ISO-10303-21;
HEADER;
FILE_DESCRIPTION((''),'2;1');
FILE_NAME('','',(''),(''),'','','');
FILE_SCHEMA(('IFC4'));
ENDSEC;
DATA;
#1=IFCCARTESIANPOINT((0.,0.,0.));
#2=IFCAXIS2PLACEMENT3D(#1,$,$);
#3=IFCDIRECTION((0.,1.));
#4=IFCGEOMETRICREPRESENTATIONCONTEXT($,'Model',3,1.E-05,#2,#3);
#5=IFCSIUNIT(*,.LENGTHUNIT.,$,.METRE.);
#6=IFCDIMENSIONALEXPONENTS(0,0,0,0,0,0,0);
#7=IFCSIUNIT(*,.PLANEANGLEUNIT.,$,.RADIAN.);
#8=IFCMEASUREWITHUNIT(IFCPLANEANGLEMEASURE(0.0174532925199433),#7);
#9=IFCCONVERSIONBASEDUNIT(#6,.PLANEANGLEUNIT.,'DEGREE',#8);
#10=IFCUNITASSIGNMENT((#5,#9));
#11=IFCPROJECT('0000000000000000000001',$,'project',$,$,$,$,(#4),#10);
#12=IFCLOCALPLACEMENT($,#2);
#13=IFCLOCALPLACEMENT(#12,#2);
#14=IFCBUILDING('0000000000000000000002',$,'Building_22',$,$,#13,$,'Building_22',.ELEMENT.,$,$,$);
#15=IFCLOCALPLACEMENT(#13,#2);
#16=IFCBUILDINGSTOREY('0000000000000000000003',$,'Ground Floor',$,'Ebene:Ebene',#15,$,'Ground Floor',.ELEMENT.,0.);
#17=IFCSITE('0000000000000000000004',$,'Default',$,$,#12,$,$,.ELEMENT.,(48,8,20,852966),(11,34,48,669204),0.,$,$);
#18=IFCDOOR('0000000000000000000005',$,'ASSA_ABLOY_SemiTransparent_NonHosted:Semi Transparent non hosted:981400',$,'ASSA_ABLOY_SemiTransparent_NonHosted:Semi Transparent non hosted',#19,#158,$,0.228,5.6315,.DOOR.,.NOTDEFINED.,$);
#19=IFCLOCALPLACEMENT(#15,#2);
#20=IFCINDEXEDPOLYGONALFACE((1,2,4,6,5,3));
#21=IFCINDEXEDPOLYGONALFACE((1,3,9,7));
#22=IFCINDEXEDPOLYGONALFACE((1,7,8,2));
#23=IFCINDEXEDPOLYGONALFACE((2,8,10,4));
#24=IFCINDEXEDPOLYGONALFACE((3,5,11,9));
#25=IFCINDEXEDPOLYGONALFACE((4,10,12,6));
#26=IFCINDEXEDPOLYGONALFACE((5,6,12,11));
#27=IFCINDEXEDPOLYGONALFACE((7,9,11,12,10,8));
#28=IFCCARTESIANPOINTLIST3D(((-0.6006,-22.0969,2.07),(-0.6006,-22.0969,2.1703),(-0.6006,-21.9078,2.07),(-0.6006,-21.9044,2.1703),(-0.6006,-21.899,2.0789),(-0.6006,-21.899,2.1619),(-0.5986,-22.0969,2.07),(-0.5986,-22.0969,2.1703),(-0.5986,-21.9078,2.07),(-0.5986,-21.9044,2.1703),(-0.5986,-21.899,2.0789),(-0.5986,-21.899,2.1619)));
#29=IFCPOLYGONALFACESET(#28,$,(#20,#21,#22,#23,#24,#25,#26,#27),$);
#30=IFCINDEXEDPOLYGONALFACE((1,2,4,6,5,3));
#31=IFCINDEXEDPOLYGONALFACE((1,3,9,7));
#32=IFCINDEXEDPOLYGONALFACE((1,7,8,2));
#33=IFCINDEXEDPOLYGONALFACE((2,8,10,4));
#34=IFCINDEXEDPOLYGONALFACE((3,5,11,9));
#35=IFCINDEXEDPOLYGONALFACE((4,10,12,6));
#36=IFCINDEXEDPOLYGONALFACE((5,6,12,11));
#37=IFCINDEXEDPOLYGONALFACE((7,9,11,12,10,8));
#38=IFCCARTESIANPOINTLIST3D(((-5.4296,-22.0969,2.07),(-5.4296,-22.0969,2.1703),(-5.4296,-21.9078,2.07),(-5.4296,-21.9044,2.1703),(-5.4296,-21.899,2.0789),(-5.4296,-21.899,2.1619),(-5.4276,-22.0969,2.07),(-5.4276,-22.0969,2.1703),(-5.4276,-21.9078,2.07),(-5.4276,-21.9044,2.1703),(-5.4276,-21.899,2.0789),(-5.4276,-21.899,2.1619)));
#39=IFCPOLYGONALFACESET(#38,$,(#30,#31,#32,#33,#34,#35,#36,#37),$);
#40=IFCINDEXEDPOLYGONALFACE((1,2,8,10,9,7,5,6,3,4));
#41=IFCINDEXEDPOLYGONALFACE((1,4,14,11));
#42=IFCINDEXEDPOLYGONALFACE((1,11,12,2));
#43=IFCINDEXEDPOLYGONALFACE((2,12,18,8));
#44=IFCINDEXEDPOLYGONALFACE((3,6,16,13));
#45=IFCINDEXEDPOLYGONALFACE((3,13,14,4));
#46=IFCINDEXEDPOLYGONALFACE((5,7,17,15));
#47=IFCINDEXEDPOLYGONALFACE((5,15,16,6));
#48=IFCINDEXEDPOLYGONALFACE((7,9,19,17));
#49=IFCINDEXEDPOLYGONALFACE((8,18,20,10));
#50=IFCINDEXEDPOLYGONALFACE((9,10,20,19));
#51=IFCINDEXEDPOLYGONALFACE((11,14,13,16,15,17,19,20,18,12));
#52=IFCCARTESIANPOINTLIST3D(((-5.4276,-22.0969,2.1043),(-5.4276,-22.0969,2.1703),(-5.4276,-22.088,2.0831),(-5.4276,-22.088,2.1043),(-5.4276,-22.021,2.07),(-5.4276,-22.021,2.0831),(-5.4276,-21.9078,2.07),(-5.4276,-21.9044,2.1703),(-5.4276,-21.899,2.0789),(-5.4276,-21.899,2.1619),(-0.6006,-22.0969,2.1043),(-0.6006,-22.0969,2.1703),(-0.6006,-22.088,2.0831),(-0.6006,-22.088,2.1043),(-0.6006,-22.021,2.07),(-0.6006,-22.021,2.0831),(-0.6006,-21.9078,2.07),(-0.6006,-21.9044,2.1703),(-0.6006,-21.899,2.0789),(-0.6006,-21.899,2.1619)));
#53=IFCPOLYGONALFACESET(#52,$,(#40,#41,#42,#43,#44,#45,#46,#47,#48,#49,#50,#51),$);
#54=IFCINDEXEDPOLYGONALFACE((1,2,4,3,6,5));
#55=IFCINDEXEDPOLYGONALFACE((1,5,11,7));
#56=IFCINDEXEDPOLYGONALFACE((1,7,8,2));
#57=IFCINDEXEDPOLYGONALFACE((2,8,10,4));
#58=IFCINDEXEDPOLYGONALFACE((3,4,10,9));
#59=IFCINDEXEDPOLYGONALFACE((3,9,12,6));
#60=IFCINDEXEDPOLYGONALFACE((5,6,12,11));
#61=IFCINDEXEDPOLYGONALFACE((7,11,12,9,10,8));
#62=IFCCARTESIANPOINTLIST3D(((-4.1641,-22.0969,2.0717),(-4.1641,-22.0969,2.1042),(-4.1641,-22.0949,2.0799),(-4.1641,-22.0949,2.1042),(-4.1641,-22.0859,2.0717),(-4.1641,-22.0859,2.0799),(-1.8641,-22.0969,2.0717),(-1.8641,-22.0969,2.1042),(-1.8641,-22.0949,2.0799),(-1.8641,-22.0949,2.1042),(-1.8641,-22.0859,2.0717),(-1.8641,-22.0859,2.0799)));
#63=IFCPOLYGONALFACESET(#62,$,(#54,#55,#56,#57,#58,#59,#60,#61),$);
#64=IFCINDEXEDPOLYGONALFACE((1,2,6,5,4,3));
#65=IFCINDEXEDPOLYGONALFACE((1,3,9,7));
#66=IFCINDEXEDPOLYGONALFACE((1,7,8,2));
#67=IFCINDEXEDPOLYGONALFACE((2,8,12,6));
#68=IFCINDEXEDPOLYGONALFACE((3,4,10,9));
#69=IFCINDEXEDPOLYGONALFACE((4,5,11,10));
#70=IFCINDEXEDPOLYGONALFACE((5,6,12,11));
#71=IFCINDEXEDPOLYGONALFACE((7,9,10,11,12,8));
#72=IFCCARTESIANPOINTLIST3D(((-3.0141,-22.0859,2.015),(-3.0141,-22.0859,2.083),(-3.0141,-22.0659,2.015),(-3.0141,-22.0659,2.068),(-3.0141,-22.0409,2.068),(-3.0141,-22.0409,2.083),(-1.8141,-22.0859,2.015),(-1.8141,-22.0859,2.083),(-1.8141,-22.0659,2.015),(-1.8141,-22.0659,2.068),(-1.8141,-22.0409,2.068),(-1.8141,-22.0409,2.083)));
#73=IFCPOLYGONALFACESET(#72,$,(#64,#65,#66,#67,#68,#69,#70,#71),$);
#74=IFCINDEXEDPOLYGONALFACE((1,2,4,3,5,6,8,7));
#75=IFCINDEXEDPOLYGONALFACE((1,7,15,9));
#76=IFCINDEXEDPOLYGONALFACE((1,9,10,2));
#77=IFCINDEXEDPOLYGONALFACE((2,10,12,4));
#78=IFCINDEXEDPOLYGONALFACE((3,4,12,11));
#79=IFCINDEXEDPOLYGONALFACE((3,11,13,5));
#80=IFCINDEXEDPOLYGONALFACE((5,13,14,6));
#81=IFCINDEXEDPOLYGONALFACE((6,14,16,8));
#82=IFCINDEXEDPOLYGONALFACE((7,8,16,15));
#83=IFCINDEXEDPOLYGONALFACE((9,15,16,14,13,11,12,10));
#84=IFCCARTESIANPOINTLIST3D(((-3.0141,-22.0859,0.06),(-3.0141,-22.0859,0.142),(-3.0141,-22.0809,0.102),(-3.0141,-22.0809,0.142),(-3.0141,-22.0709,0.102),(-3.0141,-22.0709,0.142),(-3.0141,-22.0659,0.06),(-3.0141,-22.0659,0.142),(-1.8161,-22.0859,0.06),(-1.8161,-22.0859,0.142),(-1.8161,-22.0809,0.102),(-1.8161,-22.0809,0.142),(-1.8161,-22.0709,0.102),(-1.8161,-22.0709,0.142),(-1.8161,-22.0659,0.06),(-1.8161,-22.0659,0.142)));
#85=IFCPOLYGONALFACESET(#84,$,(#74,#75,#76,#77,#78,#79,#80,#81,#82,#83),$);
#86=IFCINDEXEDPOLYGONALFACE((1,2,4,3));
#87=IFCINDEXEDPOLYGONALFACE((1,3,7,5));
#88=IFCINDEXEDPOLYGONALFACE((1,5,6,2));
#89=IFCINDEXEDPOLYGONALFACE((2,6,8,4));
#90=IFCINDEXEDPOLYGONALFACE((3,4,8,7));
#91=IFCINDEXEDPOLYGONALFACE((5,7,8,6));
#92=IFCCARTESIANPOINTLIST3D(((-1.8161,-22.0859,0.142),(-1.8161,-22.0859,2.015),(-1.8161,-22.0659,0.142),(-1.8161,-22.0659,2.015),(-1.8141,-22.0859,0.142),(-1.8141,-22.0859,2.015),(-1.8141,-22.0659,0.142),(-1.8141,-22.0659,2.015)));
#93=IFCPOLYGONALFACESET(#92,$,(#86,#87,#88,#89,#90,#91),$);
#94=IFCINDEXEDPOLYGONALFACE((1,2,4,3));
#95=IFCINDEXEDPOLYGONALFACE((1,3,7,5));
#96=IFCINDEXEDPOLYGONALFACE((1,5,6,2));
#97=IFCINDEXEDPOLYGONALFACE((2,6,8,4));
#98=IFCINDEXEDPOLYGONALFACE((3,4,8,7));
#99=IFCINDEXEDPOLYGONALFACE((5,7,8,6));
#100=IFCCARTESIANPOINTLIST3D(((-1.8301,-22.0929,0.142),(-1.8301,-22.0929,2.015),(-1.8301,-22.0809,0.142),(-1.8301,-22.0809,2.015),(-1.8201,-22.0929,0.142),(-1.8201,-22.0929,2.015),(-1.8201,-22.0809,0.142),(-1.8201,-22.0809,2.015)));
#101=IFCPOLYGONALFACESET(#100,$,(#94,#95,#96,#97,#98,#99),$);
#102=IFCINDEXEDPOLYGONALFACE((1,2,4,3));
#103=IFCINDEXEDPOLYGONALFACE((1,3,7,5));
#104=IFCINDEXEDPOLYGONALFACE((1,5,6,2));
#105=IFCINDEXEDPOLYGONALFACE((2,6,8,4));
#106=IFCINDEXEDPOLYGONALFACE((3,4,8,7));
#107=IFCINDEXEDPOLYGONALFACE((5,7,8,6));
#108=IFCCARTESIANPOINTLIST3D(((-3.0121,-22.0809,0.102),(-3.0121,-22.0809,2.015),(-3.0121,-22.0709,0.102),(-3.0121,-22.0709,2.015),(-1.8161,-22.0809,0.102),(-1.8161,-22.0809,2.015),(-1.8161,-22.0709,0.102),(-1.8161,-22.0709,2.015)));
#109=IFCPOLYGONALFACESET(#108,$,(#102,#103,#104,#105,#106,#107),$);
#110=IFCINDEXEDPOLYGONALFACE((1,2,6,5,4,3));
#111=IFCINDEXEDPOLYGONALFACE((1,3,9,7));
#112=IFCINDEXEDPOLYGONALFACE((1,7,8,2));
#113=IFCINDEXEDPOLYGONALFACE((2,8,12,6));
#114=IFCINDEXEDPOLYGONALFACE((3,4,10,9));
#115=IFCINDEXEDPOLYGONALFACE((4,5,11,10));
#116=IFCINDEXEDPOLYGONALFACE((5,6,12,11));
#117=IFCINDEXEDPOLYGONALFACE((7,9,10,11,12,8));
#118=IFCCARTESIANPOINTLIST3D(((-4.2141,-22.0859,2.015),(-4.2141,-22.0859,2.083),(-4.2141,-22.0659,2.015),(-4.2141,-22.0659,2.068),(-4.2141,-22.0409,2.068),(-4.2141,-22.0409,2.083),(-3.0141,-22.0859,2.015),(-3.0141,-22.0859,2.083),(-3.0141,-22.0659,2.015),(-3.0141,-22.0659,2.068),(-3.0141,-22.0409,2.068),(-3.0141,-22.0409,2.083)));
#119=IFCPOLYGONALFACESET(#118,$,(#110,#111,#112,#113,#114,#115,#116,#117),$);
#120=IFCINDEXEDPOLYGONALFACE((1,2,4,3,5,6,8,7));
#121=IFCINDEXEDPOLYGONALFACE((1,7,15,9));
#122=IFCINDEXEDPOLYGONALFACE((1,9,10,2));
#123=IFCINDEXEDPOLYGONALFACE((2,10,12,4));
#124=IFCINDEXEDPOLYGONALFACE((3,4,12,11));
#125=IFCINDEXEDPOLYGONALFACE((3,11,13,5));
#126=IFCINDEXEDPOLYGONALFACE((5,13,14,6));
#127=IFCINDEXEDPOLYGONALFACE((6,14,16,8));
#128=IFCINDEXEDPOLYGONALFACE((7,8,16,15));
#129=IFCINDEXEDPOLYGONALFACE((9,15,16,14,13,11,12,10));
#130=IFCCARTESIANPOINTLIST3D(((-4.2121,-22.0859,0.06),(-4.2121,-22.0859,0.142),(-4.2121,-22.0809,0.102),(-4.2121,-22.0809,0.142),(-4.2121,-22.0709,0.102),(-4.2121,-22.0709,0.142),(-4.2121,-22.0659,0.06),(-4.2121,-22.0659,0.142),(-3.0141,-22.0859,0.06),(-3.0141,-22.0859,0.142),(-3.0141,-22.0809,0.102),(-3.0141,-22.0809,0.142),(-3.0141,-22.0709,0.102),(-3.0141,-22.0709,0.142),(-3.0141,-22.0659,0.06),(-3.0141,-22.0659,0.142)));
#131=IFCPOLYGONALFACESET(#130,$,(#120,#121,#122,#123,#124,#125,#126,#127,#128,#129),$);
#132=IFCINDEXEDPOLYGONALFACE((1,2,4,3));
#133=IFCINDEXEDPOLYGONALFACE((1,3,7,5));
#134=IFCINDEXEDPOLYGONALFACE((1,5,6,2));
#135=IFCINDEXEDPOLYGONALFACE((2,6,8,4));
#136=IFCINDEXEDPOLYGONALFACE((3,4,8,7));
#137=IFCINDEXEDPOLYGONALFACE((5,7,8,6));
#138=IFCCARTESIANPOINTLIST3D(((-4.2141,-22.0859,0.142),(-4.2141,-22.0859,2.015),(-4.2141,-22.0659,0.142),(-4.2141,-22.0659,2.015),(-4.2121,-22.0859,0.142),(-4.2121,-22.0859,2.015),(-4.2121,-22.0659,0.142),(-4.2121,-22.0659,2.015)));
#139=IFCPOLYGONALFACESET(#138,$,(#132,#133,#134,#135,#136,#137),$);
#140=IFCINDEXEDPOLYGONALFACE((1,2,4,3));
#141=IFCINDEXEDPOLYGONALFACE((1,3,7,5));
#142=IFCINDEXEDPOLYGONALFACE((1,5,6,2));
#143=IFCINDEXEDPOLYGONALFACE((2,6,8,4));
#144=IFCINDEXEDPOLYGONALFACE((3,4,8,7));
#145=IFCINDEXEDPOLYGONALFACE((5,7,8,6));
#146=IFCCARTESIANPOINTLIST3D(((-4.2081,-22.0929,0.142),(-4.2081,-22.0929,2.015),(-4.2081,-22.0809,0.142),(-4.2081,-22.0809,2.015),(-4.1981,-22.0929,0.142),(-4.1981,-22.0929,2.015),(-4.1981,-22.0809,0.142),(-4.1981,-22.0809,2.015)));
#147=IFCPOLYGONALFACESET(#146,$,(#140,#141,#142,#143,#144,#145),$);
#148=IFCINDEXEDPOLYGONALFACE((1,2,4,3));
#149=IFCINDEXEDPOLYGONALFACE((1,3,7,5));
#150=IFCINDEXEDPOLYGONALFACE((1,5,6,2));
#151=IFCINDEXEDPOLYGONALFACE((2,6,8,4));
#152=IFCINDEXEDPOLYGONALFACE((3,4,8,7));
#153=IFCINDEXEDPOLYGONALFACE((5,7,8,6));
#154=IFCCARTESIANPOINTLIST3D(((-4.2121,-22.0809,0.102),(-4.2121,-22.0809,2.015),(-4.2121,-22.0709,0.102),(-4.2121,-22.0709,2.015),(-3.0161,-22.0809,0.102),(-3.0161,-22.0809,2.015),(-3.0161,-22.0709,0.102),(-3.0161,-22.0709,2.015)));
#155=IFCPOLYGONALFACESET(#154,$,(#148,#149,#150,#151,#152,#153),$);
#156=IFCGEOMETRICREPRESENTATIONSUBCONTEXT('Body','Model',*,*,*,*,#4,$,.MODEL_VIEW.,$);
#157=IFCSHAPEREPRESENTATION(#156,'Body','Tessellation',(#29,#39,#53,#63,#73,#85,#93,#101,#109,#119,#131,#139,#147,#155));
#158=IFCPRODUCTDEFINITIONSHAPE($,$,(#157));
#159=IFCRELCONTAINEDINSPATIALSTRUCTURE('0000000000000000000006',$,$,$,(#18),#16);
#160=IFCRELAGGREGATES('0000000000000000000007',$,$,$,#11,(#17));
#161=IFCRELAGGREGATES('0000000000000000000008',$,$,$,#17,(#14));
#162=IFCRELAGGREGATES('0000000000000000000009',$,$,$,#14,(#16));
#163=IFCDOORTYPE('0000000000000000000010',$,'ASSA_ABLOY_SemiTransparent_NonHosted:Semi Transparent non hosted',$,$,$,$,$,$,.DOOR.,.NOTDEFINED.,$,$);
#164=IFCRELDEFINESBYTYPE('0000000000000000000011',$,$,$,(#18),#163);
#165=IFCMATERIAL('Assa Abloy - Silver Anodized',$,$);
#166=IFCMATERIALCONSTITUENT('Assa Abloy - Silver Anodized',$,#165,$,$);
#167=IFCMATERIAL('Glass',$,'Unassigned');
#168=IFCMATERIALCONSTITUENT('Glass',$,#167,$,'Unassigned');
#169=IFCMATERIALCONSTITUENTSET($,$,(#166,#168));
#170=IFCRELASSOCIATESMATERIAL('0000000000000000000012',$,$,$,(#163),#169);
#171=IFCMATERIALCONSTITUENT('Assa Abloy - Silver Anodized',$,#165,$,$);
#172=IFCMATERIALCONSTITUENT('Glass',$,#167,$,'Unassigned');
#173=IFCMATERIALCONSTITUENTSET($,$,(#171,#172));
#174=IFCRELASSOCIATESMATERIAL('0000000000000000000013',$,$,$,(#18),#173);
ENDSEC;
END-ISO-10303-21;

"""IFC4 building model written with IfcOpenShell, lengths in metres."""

from ifc_helpers import new_model, entity, si_unit, converted_unit, direction, frame, origin, place, context, subcontext, project, spatial, indexed_curve, outline, extrude, source, transform, mapped, material, constituent, constituent_set, type_object, type_shapes, element, save


model = new_model("IFC4")

# Units and contexts
model_context = context("Model", 3, precision=1e-05, world=origin(), true_north=direction((0.0, 1.0)))
body_context = subcontext(model_context, "Body", "Model", "MODEL_VIEW")
ifc_project = project(units=[si_unit("LENGTHUNIT", "METRE"), converted_unit("PLANEANGLEUNIT", "DEGREE", entity("IfcPlaneAngleMeasure", 0.0174532925199433), si_unit("PLANEANGLEUNIT", "RADIAN"), dimensions=[0, 0, 0, 0, 0, 0, 0])], contexts=[model_context])

# Site, building, storey
site_placement = place(None, origin())
site = spatial("IfcSite", under=ifc_project, at=site_placement, Name="Default", CompositionType="ELEMENT", RefLatitude=(48, 8, 20, 852966), RefLongitude=(11, 34, 48, 669204), RefElevation=0.0)
building_placement = place(site_placement, origin())
building = spatial("IfcBuilding", under=site, at=building_placement, Name="Building_22", LongName="Building_22", CompositionType="ELEMENT")
storey_placement = place(building_placement, origin())
storey = spatial("IfcBuildingStorey", under=building, at=storey_placement, Name="Ground Floor", ObjectType="Ebene:Ebene", LongName="Ground Floor", CompositionType="ELEMENT", Elevation=0.0)

# Door
ifc_material_1 = material(Name="Assa Abloy - Silver Anodized")
ifc_constituent_1 = constituent(ifc_material_1, Name="Assa Abloy - Silver Anodized")
ifc_material_2 = material(Name="Glass", Category="Unassigned")
ifc_constituent_2 = constituent(ifc_material_2, Name="Glass", Category="Unassigned")
ifc_constituent_set_1 = constituent_set(constituents=[ifc_constituent_1, ifc_constituent_2])
ifc_constituent_3 = constituent(ifc_material_1, Name="Assa Abloy - Silver Anodized")
ifc_constituent_4 = constituent(ifc_material_2, Name="Glass", Category="Unassigned")
ifc_constituent_set_2 = constituent_set(constituents=[ifc_constituent_3, ifc_constituent_4])
door_type = type_object("IfcDoorType", Name="ASSA_ABLOY_SemiTransparent_NonHosted:Semi Transparent non hosted", OperationType="NOTDEFINED", PredefinedType="DOOR", material=ifc_constituent_set_2)
shared_shape_1 = source(origin(), body_context, "Body", "SweptSolid", [
    extrude(outline(indexed_curve([(-0.0629, -0.0501), (0.1295, -0.0501), (0.1295, 0.0502), (-0.0595, 0.0502), (-0.0683, 0.0413), (-0.0683, -0.0417), (-0.0629, -0.0501)], self_intersect=False)), frame((2.4135, 0.1295, 2.0602), z_axis=(1.0, 0.0, 0.0), x_axis=(0.0, -1.0, 0.0)), (0.0, 0.0, 1.0), 0.002),
    extrude(outline(indexed_curve([(-0.0629, -0.0501), (0.1295, -0.0501), (0.1295, 0.0502), (-0.0595, 0.0502), (-0.0683, 0.0413), (-0.0683, -0.0417), (-0.0629, -0.0501)], self_intersect=False)), frame((-2.4155, 0.1295, 2.0602), z_axis=(1.0, 0.0, 0.0), x_axis=(0.0, -1.0, 0.0)), (0.0, 0.0, 1.0), 0.002),
    extrude(outline(indexed_curve([(-0.0947, 0.0054), (-0.0947, -0.0607), (0.0978, -0.0607), (0.1032, -0.0523), (0.1032, 0.0307), (0.0943, 0.0396), (-0.0188, 0.0396), (-0.0188, 0.0265), (-0.0858, 0.0265), (-0.0858, 0.0054), (-0.0947, 0.0054)], self_intersect=False)), frame((-2.4135, 0.0947, 2.0496), z_axis=(-1.0, 0.0, 0.0), x_axis=(0.0, 1.0, 0.0)), (0.0, 0.0, -1.0), 4.827),
    extrude(outline(indexed_curve([(-0.0136, -0.0067), (-0.0054, -0.0067), (-0.0054, 0.0023), (0.0189, 0.0023), (0.0189, 0.0043), (-0.0136, 0.0043), (-0.0136, -0.0067)], self_intersect=False)), frame((-1.15, 0.0043, 2.0253), z_axis=(1.0, 0.0, 0.0), x_axis=(0.0, 0.0, 1.0)), (0.0, 0.0, 1.0), 2.3),
    extrude(outline(indexed_curve([(-0.0233, -0.0277), (0.0217, -0.0277), (0.0217, 0.0403), (0.0017, 0.0403), (0.0017, -0.0127), (-0.0233, -0.0127), (-0.0233, -0.0277)], self_intersect=False)), frame((0.0, 0.0327, 1.9953), z_axis=(1.0, 0.0, 0.0), x_axis=(0.0, -1.0, 0.0)), (0.0, 0.0, 1.0), 1.2),
    extrude(outline(indexed_curve([(-0.01, -0.0515), (0.01, -0.0515), (0.01, 0.0305), (0.005, 0.0305), (0.005, -0.0095), (-0.005, -0.0095), (-0.005, 0.0305), (-0.01, 0.0305), (-0.01, -0.0515)], self_intersect=False)), frame((0.0, 0.021, 0.0515), z_axis=(1.0, 0.0, 0.0), x_axis=(0.0, 1.0, 0.0)), (0.0, 0.0, 1.0), 1.198),
    extrude(outline(indexed_curve([(-0.001, -0.01), (0.001, -0.01), (0.001, 0.01), (-0.001, 0.01), (-0.001, -0.01)], self_intersect=False)), frame((1.199, 0.021, 0.082), z_axis=(0.0, 0.0, 1.0), x_axis=(-1.0, 0.0, 0.0)), (0.0, 0.0, 1.0), 1.873),
    extrude(outline(indexed_curve([(-0.005, -0.006), (0.005, -0.006), (0.005, 0.006), (-0.005, 0.006), (-0.005, -0.006)], self_intersect=False)), frame((1.189, 0.01, 0.082)), (0.0, 0.0, 1.0), 1.873),
    extrude(outline(indexed_curve([(-0.598, -0.005), (0.598, -0.005), (0.598, 0.005), (-0.598, 0.005), (-0.598, -0.005)], self_intersect=False)), frame((0.6, 0.021, 0.042), z_axis=(0.0, 0.0, 1.0), x_axis=(-1.0, 0.0, 0.0)), (0.0, 0.0, 1.0), 1.913),
    extrude(outline(indexed_curve([(-0.0233, -0.0277), (0.0217, -0.0277), (0.0217, 0.0403), (0.0017, 0.0403), (0.0017, -0.0127), (-0.0233, -0.0127), (-0.0233, -0.0277)], self_intersect=False)), frame((-1.2, 0.0327, 1.9953), z_axis=(1.0, 0.0, 0.0), x_axis=(0.0, -1.0, 0.0)), (0.0, 0.0, 1.0), 1.2),
    extrude(outline(indexed_curve([(-0.01, -0.0515), (0.01, -0.0515), (0.01, 0.0305), (0.005, 0.0305), (0.005, -0.0095), (-0.005, -0.0095), (-0.005, 0.0305), (-0.01, 0.0305), (-0.01, -0.0515)], self_intersect=False)), frame((-1.198, 0.021, 0.0515), z_axis=(1.0, 0.0, 0.0), x_axis=(0.0, 1.0, 0.0)), (0.0, 0.0, 1.0), 1.198),
    extrude(outline(indexed_curve([(-0.01, -0.001), (0.01, -0.001), (0.01, 0.001), (-0.01, 0.001), (-0.01, -0.001)], self_intersect=False)), frame((-1.199, 0.021, 0.082), z_axis=(0.0, 0.0, 1.0), x_axis=(0.0, -1.0, 0.0)), (0.0, 0.0, 1.0), 1.873),
    extrude(outline(indexed_curve([(-0.006, -0.005), (0.006, -0.005), (0.006, 0.005), (-0.006, 0.005), (-0.006, -0.005)], self_intersect=False)), frame((-1.189, 0.01, 0.082), z_axis=(0.0, 0.0, 1.0), x_axis=(0.0, 1.0, 0.0)), (0.0, 0.0, 1.0), 1.873),
    extrude(outline(indexed_curve([(-0.005, -0.598), (0.005, -0.598), (0.005, 0.598), (-0.005, 0.598), (-0.005, -0.598)], self_intersect=False)), frame((-0.6, 0.021, 0.042), z_axis=(0.0, 0.0, 1.0), x_axis=(0.0, -1.0, 0.0)), (0.0, 0.0, 1.0), 1.913),
])
type_shapes(door_type, [shared_shape_1])
door_placement = place(storey_placement, frame((-3.0141, -22.0969, 0.06)))
element("IfcDoor", 1, at=door_placement, inside=storey, type_object=door_type, material=ifc_constituent_set_1, Name="ASSA_ABLOY_SemiTransparent_NonHosted:Semi Transparent non hosted:981400", ObjectType="ASSA_ABLOY_SemiTransparent_NonHosted:Semi Transparent non hosted", OperationType="NOTDEFINED", OverallHeight=0.228, OverallWidth=5.6315, PredefinedType="DOOR", context=body_context, shape_type="MappedRepresentation", body=[
    mapped(shared_shape_1, transform((0.0, 0.0, 0.0), scale=1.0)),
])

save(model, "model.ifc")
